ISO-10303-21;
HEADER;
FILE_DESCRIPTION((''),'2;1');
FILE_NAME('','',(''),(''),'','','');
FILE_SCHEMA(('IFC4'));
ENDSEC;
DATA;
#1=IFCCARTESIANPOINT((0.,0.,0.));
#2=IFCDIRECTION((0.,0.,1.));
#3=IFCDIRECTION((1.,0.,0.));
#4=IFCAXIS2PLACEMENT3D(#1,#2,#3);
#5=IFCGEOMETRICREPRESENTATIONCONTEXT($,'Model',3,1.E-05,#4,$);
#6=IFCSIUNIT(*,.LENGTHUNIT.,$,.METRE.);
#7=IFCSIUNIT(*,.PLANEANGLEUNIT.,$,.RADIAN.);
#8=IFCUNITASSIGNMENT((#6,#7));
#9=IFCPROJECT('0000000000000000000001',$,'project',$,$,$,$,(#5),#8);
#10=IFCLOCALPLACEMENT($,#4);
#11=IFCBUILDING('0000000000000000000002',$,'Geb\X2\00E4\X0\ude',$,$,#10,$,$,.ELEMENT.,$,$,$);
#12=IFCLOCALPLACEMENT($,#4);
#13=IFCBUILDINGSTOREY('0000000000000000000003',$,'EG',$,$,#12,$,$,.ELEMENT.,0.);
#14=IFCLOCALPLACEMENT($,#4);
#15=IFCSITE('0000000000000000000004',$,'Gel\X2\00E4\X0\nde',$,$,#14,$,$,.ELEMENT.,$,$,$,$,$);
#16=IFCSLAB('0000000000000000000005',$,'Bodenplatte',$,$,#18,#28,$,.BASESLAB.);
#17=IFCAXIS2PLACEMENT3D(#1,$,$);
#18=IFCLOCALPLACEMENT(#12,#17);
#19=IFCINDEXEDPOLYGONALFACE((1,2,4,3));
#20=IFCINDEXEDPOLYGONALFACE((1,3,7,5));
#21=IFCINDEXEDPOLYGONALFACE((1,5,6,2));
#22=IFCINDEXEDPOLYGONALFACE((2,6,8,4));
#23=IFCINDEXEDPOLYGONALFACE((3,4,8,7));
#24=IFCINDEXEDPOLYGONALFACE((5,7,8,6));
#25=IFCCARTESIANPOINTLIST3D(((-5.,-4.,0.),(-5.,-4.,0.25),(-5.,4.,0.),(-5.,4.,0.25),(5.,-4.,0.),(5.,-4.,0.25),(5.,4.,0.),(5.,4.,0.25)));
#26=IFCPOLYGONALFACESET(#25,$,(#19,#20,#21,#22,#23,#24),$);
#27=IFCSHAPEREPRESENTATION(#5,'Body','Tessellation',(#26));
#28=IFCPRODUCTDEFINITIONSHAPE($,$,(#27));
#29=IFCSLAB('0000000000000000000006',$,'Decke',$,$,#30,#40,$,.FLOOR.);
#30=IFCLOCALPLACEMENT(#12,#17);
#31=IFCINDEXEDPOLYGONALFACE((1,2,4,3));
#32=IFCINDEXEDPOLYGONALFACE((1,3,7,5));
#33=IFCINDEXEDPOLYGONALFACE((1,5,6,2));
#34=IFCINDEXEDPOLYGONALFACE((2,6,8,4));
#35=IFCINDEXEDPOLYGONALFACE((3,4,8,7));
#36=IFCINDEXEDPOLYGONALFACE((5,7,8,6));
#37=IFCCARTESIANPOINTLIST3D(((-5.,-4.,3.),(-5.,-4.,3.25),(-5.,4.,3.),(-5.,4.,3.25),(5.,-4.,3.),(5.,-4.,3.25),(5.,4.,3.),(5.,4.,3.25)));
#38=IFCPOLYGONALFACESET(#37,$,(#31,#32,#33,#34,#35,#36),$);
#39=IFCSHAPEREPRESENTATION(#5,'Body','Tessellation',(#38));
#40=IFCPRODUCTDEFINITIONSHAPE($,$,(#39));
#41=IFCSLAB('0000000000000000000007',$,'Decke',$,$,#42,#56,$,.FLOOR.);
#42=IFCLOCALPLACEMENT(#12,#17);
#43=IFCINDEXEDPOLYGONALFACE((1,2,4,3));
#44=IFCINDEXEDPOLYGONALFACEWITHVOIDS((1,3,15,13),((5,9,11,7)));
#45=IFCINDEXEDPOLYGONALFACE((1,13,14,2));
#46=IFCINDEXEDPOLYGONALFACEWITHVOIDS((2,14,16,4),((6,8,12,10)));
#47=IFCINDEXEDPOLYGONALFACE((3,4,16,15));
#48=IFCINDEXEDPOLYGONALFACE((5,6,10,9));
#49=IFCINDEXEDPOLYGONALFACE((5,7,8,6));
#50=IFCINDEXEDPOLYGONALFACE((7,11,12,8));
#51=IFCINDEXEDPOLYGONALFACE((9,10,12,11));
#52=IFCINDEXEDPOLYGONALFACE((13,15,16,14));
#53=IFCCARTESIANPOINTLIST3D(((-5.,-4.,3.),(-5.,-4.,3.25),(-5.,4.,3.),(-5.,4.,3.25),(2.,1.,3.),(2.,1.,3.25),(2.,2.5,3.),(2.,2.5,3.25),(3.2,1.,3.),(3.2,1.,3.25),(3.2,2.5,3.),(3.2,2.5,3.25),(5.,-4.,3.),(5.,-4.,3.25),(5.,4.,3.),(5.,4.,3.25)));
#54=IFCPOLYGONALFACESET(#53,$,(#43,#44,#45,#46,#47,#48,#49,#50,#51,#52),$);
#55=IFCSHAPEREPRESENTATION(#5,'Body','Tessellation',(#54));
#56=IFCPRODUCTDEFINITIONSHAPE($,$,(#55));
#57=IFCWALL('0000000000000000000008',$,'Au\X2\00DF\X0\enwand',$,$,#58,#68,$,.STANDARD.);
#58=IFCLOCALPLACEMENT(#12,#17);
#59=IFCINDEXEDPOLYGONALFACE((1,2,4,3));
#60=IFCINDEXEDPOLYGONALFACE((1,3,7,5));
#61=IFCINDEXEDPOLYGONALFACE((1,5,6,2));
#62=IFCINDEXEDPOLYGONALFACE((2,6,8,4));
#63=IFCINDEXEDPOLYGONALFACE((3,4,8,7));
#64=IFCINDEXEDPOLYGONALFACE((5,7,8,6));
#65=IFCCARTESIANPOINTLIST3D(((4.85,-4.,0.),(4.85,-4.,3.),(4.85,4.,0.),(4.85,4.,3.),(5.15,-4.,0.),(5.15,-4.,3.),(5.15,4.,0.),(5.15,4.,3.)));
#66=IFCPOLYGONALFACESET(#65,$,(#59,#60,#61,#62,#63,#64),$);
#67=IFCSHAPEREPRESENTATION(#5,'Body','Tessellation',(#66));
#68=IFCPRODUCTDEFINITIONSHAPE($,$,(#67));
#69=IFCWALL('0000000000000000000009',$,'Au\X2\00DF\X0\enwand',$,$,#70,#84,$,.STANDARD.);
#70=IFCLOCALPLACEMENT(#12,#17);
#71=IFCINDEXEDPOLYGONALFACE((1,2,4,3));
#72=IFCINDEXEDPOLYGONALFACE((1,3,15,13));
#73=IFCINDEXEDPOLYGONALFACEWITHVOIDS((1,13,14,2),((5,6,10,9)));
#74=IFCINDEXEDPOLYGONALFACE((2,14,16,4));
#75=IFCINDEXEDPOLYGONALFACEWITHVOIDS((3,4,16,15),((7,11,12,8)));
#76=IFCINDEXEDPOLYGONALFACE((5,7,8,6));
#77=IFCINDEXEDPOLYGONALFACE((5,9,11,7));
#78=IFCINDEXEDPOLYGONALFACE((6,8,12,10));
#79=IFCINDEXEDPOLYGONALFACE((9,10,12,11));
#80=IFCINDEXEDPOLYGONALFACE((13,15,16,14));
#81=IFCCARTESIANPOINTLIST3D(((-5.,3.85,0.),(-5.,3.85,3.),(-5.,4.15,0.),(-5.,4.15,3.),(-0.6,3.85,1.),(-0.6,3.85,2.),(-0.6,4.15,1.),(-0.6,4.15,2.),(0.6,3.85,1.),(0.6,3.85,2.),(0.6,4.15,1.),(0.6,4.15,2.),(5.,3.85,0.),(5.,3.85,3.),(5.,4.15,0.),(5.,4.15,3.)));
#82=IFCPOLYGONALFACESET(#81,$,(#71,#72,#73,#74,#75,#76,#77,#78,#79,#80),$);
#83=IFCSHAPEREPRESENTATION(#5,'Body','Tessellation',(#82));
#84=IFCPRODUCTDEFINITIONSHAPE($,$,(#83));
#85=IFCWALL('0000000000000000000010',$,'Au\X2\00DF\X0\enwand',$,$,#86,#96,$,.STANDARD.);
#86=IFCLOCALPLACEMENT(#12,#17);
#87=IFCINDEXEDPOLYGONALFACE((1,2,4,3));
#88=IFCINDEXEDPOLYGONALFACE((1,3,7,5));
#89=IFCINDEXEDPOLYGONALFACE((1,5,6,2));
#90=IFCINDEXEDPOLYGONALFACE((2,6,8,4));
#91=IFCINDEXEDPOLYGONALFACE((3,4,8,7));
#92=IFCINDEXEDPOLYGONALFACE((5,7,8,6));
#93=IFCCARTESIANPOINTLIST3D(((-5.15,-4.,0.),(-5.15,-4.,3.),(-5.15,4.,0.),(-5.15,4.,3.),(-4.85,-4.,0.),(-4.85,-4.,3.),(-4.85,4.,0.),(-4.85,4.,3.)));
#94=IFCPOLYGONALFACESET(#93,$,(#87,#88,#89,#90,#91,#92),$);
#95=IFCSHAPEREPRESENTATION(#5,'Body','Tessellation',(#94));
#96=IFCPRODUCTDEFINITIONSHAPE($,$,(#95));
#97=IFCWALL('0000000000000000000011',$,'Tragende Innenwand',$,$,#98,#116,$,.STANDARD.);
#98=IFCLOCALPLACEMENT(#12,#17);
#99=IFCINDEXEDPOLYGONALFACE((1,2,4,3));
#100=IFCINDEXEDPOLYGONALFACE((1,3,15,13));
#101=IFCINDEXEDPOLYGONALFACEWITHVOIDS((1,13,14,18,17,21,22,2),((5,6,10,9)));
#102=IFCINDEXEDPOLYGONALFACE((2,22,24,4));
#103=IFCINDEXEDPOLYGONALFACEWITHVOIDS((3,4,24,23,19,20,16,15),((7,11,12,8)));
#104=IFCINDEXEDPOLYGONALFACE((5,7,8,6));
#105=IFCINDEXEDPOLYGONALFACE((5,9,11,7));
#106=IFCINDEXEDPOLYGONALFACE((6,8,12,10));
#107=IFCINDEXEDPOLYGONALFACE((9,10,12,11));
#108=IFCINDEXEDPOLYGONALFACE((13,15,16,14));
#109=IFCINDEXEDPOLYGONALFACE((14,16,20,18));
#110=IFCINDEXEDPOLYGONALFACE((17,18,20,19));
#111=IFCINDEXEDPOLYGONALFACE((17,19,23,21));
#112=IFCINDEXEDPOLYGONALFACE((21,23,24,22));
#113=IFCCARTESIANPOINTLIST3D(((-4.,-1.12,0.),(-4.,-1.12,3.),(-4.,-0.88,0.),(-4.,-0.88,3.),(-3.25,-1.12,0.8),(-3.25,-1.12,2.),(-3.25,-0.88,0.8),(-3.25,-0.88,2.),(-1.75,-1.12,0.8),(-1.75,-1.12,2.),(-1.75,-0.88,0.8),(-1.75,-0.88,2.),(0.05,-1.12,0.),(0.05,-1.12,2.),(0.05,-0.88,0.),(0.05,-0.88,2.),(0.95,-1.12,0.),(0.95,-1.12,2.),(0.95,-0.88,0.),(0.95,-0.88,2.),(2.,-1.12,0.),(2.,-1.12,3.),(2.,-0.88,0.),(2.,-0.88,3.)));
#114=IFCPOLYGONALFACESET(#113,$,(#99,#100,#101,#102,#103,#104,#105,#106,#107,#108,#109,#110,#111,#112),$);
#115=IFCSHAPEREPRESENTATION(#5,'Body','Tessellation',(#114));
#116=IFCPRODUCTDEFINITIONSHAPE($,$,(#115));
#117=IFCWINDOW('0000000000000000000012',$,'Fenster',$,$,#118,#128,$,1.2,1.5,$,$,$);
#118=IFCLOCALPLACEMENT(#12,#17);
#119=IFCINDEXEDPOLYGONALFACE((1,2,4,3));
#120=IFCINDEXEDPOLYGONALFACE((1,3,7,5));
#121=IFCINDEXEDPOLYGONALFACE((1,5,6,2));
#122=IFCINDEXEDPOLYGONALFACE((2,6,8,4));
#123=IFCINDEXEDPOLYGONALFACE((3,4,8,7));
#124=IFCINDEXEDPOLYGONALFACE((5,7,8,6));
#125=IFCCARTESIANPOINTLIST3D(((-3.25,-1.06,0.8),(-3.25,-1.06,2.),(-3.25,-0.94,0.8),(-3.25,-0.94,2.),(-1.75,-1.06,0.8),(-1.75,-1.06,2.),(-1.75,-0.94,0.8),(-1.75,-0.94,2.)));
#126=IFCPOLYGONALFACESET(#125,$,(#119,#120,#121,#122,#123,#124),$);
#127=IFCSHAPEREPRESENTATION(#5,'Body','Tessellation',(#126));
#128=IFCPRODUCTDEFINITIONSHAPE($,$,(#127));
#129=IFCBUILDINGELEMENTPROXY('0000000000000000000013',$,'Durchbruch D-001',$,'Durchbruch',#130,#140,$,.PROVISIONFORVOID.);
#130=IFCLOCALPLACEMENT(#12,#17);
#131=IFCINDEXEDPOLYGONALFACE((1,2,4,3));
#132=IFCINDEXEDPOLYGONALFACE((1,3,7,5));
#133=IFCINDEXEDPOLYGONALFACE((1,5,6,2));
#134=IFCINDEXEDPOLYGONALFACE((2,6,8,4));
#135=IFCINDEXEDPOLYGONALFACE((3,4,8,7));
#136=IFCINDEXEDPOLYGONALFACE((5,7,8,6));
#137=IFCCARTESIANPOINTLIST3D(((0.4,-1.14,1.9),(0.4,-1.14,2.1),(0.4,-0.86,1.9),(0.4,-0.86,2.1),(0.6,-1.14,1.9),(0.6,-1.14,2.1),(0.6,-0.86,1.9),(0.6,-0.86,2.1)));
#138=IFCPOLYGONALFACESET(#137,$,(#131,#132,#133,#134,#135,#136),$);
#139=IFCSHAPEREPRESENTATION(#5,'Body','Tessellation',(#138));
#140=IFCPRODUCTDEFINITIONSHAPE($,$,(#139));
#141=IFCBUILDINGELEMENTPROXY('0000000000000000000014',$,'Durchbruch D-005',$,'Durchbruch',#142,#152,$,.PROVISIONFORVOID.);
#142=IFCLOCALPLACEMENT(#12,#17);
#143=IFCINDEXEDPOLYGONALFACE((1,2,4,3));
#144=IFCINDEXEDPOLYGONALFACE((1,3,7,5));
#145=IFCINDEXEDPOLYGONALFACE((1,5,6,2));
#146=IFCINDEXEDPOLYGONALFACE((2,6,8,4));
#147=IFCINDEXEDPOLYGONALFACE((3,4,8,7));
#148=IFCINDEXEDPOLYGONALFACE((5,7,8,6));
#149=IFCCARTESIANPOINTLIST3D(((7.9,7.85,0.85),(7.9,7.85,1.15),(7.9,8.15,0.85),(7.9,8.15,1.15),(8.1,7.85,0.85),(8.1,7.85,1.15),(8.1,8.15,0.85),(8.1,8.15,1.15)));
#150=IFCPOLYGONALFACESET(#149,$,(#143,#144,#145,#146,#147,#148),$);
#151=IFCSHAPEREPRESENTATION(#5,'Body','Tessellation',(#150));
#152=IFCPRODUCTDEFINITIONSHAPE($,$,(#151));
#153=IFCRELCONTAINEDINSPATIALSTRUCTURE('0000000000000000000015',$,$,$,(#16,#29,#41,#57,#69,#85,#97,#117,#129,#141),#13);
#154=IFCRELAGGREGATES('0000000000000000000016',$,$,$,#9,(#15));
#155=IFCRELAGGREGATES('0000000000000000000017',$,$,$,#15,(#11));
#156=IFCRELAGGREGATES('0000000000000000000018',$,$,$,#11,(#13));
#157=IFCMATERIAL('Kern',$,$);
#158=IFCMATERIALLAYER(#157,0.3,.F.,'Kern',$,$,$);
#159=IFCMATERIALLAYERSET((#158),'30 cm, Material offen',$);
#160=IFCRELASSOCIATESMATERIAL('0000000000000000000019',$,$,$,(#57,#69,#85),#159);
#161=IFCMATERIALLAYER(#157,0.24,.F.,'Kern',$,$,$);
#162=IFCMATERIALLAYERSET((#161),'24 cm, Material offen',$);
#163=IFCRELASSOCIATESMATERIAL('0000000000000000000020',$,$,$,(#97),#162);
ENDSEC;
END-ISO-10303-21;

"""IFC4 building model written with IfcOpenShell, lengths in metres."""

from ifc_helpers import new_model, si_unit, frame, origin_with_axes, origin_2d, place, context, project, spatial, polyline, rectangle, outline, extrude, material, layer, layer_set, element, fill, save


model = new_model("IFC4")

# Units and contexts
model_context = context("Model", 3, precision=1e-05, world=origin_with_axes())
ifc_project = project(units=[si_unit("LENGTHUNIT", "METRE"), si_unit("PLANEANGLEUNIT", "RADIAN")], contexts=[model_context])

# Site, building, storey
site_placement = place(None, origin_with_axes())
site = spatial("IfcSite", under=ifc_project, at=site_placement, Name="Gelände", CompositionType="ELEMENT")
building_placement = place(None, origin_with_axes())
building = spatial("IfcBuilding", under=site, at=building_placement, Name="Gebäude", CompositionType="ELEMENT")
storey_placement = place(None, origin_with_axes())
storey = spatial("IfcBuildingStorey", under=building, at=storey_placement, Name="EG", CompositionType="ELEMENT", Elevation=0.0)

# Slabs
slab_1_placement = place(None, origin_with_axes())
element("IfcSlab", 1, at=slab_1_placement, inside=storey, Name="Bodenplatte", PredefinedType="BASESLAB", context=model_context, shape_type="SweptSolid", body=[
    extrude(outline(polyline([(-5.0, -4.0), (5.0, -4.0), (5.0, 4.0), (-5.0, 4.0), (-5.0, -4.0)])), origin_with_axes(), (0.0, 0.0, 1.0), 0.25),
])
slab_2_placement = place(None, frame((0.0, 0.0, 3.0), z_axis=(0.0, 0.0, 1.0), x_axis=(1.0, 0.0, 0.0)))
element("IfcSlab", 2, at=slab_2_placement, inside=storey, Name="Decke", PredefinedType="FLOOR", context=model_context, shape_type="SweptSolid", body=[
    extrude(outline(polyline([(-5.0, -4.0), (5.0, -4.0), (5.0, 4.0), (-5.0, 4.0), (-5.0, -4.0)])), origin_with_axes(), (0.0, 0.0, 1.0), 0.25),
])

# Slab, opening
slab_3_placement = place(None, frame((0.0, 0.0, 3.0), z_axis=(0.0, 0.0, 1.0), x_axis=(1.0, 0.0, 0.0)))
slab_3 = element("IfcSlab", 3, at=slab_3_placement, inside=storey, Name="Decke", PredefinedType="FLOOR", context=model_context, shape_type="SweptSolid", body=[
    extrude(outline(polyline([(-5.0, -4.0), (5.0, -4.0), (5.0, 4.0), (-5.0, 4.0), (-5.0, -4.0)])), origin_with_axes(), (0.0, 0.0, 1.0), 0.25),
])
opening_1_placement = place(slab_3_placement, frame((0.0, 0.0, -0.02), z_axis=(0.0, 0.0, 1.0), x_axis=(1.0, 0.0, 0.0)))
element("IfcOpeningElement", 4, at=opening_1_placement, cuts=slab_3, PredefinedType="OPENING", context=model_context, shape_type="SweptSolid", body=[
    extrude(outline(polyline([(2.0, 1.0), (3.2, 1.0), (3.2, 2.5), (2.0, 2.5), (2.0, 1.0)])), origin_with_axes(), (0.0, 0.0, 1.0), 0.29),
])

# Shared definitions
ifc_material = material(Name="Kern")
ifc_layer_1 = layer(ifc_material, 0.3, ventilated=False, Name="Kern")
ifc_layer_set_1 = layer_set([ifc_layer_1], Name="30 cm, Material offen")

# Wall
wall_1_placement = place(None, frame((5.0, 0.0, 0.0), z_axis=(0.0, 0.0, 1.0), x_axis=(0.0, 1.0, 0.0)))
element("IfcWall", 5, at=wall_1_placement, inside=storey, material=ifc_layer_set_1, Name="Außenwand", PredefinedType="STANDARD", context=model_context, shape_type="SweptSolid", body=[
    extrude(rectangle(XDim=8.0, YDim=0.3, at=origin_2d()), origin_with_axes(), (0.0, 0.0, 1.0), 3.0),
])

# Wall, opening
wall_2_placement = place(None, frame((0.0, 4.0, 0.0), z_axis=(0.0, 0.0, 1.0), x_axis=(-1.0, 0.0, 0.0)))
wall_2 = element("IfcWall", 6, at=wall_2_placement, inside=storey, material=ifc_layer_set_1, Name="Außenwand", PredefinedType="STANDARD", context=model_context, shape_type="SweptSolid", body=[
    extrude(rectangle(XDim=10.0, YDim=0.3, at=origin_2d()), origin_with_axes(), (0.0, 0.0, 1.0), 3.0),
])
opening_2_placement = place(wall_2_placement, frame((0.0, 0.0, 1.0), z_axis=(0.0, 0.0, 1.0), x_axis=(1.0, 0.0, 0.0)))
element("IfcOpeningElement", 7, at=opening_2_placement, cuts=wall_2, PredefinedType="OPENING", context=model_context, shape_type="SweptSolid", body=[
    extrude(rectangle(XDim=1.2, YDim=0.34, at=origin_2d()), origin_with_axes(), (0.0, 0.0, 1.0), 1.0),
])

# Wall
wall_3_placement = place(None, frame((-5.0, 0.0, 0.0), z_axis=(0.0, 0.0, 1.0), x_axis=(0.0, -1.0, 0.0)))
element("IfcWall", 8, at=wall_3_placement, inside=storey, material=ifc_layer_set_1, Name="Außenwand", PredefinedType="STANDARD", context=model_context, shape_type="SweptSolid", body=[
    extrude(rectangle(XDim=8.0, YDim=0.3, at=origin_2d()), origin_with_axes(), (0.0, 0.0, 1.0), 3.0),
])

# Wall, openings, window
ifc_layer_2 = layer(ifc_material, 0.24, ventilated=False, Name="Kern")
ifc_layer_set_2 = layer_set([ifc_layer_2], Name="24 cm, Material offen")
wall_4_placement = place(None, frame((-1.0, -1.0, 0.0), z_axis=(0.0, 0.0, 1.0), x_axis=(1.0, 0.0, 0.0)))
wall_4 = element("IfcWall", 9, at=wall_4_placement, inside=storey, material=ifc_layer_set_2, Name="Tragende Innenwand", PredefinedType="STANDARD", context=model_context, shape_type="SweptSolid", body=[
    extrude(rectangle(XDim=6.0, YDim=0.24, at=origin_2d()), origin_with_axes(), (0.0, 0.0, 1.0), 3.0),
])
opening_3_placement = place(wall_4_placement, frame((-1.5, 0.0, 0.8), z_axis=(0.0, 0.0, 1.0), x_axis=(1.0, 0.0, 0.0)))
opening_3 = element("IfcOpeningElement", 10, at=opening_3_placement, cuts=wall_4, PredefinedType="OPENING", context=model_context, shape_type="SweptSolid", body=[
    extrude(rectangle(XDim=1.5, YDim=0.28, at=origin_2d()), origin_with_axes(), (0.0, 0.0, 1.0), 1.2),
])
opening_4_placement = place(wall_4_placement, frame((1.5, 0.0, 0.0), z_axis=(0.0, 0.0, 1.0), x_axis=(1.0, 0.0, 0.0)))
element("IfcOpeningElement", 11, at=opening_4_placement, cuts=wall_4, PredefinedType="OPENING", context=model_context, shape_type="SweptSolid", body=[
    extrude(rectangle(XDim=0.9, YDim=0.28, at=origin_2d()), origin_with_axes(), (0.0, 0.0, 1.0), 2.0),
])
opening_5_placement = place(wall_4_placement, frame((-1.0, 0.0, 1.3), z_axis=(0.0, 0.0, 1.0), x_axis=(1.0, 0.0, 0.0)))
element("IfcOpeningElement", 12, at=opening_5_placement, cuts=wall_4, PredefinedType="OPENING", context=model_context, shape_type="SweptSolid", body=[
    extrude(rectangle(XDim=0.3, YDim=0.28, at=origin_2d()), origin_with_axes(), (0.0, 0.0, 1.0), 0.4),
])
window_placement = place(opening_3_placement, origin_with_axes())
window = element("IfcWindow", 13, at=window_placement, inside=storey, Name="Fenster", OverallHeight=1.2, OverallWidth=1.5, context=model_context, shape_type="SweptSolid", body=[
    extrude(rectangle(XDim=1.5, YDim=0.12, at=origin_2d()), origin_with_axes(), (0.0, 0.0, 1.0), 1.2),
])
fill(opening_3, window)

# Building element proxies
proxy_1_placement = place(None, frame((0.5, -1.0, 1.9), z_axis=(0.0, 0.0, 1.0), x_axis=(1.0, 0.0, 0.0)))
element("IfcBuildingElementProxy", 14, at=proxy_1_placement, inside=storey, Name="Durchbruch D-001", ObjectType="Durchbruch", PredefinedType="PROVISIONFORVOID", context=model_context, shape_type="SweptSolid", body=[
    extrude(rectangle(XDim=0.2, YDim=0.28, at=origin_2d()), origin_with_axes(), (0.0, 0.0, 1.0), 0.2),
])
proxy_2_placement = place(None, frame((8.0, 8.0, 0.85), z_axis=(0.0, 0.0, 1.0), x_axis=(1.0, 0.0, 0.0)))
element("IfcBuildingElementProxy", 15, at=proxy_2_placement, inside=storey, Name="Durchbruch D-005", ObjectType="Durchbruch", PredefinedType="PROVISIONFORVOID", context=model_context, shape_type="SweptSolid", body=[
    extrude(rectangle(XDim=0.2, YDim=0.3, at=origin_2d()), origin_with_axes(), (0.0, 0.0, 1.0), 0.3),
])

save(model, "model.ifc")
